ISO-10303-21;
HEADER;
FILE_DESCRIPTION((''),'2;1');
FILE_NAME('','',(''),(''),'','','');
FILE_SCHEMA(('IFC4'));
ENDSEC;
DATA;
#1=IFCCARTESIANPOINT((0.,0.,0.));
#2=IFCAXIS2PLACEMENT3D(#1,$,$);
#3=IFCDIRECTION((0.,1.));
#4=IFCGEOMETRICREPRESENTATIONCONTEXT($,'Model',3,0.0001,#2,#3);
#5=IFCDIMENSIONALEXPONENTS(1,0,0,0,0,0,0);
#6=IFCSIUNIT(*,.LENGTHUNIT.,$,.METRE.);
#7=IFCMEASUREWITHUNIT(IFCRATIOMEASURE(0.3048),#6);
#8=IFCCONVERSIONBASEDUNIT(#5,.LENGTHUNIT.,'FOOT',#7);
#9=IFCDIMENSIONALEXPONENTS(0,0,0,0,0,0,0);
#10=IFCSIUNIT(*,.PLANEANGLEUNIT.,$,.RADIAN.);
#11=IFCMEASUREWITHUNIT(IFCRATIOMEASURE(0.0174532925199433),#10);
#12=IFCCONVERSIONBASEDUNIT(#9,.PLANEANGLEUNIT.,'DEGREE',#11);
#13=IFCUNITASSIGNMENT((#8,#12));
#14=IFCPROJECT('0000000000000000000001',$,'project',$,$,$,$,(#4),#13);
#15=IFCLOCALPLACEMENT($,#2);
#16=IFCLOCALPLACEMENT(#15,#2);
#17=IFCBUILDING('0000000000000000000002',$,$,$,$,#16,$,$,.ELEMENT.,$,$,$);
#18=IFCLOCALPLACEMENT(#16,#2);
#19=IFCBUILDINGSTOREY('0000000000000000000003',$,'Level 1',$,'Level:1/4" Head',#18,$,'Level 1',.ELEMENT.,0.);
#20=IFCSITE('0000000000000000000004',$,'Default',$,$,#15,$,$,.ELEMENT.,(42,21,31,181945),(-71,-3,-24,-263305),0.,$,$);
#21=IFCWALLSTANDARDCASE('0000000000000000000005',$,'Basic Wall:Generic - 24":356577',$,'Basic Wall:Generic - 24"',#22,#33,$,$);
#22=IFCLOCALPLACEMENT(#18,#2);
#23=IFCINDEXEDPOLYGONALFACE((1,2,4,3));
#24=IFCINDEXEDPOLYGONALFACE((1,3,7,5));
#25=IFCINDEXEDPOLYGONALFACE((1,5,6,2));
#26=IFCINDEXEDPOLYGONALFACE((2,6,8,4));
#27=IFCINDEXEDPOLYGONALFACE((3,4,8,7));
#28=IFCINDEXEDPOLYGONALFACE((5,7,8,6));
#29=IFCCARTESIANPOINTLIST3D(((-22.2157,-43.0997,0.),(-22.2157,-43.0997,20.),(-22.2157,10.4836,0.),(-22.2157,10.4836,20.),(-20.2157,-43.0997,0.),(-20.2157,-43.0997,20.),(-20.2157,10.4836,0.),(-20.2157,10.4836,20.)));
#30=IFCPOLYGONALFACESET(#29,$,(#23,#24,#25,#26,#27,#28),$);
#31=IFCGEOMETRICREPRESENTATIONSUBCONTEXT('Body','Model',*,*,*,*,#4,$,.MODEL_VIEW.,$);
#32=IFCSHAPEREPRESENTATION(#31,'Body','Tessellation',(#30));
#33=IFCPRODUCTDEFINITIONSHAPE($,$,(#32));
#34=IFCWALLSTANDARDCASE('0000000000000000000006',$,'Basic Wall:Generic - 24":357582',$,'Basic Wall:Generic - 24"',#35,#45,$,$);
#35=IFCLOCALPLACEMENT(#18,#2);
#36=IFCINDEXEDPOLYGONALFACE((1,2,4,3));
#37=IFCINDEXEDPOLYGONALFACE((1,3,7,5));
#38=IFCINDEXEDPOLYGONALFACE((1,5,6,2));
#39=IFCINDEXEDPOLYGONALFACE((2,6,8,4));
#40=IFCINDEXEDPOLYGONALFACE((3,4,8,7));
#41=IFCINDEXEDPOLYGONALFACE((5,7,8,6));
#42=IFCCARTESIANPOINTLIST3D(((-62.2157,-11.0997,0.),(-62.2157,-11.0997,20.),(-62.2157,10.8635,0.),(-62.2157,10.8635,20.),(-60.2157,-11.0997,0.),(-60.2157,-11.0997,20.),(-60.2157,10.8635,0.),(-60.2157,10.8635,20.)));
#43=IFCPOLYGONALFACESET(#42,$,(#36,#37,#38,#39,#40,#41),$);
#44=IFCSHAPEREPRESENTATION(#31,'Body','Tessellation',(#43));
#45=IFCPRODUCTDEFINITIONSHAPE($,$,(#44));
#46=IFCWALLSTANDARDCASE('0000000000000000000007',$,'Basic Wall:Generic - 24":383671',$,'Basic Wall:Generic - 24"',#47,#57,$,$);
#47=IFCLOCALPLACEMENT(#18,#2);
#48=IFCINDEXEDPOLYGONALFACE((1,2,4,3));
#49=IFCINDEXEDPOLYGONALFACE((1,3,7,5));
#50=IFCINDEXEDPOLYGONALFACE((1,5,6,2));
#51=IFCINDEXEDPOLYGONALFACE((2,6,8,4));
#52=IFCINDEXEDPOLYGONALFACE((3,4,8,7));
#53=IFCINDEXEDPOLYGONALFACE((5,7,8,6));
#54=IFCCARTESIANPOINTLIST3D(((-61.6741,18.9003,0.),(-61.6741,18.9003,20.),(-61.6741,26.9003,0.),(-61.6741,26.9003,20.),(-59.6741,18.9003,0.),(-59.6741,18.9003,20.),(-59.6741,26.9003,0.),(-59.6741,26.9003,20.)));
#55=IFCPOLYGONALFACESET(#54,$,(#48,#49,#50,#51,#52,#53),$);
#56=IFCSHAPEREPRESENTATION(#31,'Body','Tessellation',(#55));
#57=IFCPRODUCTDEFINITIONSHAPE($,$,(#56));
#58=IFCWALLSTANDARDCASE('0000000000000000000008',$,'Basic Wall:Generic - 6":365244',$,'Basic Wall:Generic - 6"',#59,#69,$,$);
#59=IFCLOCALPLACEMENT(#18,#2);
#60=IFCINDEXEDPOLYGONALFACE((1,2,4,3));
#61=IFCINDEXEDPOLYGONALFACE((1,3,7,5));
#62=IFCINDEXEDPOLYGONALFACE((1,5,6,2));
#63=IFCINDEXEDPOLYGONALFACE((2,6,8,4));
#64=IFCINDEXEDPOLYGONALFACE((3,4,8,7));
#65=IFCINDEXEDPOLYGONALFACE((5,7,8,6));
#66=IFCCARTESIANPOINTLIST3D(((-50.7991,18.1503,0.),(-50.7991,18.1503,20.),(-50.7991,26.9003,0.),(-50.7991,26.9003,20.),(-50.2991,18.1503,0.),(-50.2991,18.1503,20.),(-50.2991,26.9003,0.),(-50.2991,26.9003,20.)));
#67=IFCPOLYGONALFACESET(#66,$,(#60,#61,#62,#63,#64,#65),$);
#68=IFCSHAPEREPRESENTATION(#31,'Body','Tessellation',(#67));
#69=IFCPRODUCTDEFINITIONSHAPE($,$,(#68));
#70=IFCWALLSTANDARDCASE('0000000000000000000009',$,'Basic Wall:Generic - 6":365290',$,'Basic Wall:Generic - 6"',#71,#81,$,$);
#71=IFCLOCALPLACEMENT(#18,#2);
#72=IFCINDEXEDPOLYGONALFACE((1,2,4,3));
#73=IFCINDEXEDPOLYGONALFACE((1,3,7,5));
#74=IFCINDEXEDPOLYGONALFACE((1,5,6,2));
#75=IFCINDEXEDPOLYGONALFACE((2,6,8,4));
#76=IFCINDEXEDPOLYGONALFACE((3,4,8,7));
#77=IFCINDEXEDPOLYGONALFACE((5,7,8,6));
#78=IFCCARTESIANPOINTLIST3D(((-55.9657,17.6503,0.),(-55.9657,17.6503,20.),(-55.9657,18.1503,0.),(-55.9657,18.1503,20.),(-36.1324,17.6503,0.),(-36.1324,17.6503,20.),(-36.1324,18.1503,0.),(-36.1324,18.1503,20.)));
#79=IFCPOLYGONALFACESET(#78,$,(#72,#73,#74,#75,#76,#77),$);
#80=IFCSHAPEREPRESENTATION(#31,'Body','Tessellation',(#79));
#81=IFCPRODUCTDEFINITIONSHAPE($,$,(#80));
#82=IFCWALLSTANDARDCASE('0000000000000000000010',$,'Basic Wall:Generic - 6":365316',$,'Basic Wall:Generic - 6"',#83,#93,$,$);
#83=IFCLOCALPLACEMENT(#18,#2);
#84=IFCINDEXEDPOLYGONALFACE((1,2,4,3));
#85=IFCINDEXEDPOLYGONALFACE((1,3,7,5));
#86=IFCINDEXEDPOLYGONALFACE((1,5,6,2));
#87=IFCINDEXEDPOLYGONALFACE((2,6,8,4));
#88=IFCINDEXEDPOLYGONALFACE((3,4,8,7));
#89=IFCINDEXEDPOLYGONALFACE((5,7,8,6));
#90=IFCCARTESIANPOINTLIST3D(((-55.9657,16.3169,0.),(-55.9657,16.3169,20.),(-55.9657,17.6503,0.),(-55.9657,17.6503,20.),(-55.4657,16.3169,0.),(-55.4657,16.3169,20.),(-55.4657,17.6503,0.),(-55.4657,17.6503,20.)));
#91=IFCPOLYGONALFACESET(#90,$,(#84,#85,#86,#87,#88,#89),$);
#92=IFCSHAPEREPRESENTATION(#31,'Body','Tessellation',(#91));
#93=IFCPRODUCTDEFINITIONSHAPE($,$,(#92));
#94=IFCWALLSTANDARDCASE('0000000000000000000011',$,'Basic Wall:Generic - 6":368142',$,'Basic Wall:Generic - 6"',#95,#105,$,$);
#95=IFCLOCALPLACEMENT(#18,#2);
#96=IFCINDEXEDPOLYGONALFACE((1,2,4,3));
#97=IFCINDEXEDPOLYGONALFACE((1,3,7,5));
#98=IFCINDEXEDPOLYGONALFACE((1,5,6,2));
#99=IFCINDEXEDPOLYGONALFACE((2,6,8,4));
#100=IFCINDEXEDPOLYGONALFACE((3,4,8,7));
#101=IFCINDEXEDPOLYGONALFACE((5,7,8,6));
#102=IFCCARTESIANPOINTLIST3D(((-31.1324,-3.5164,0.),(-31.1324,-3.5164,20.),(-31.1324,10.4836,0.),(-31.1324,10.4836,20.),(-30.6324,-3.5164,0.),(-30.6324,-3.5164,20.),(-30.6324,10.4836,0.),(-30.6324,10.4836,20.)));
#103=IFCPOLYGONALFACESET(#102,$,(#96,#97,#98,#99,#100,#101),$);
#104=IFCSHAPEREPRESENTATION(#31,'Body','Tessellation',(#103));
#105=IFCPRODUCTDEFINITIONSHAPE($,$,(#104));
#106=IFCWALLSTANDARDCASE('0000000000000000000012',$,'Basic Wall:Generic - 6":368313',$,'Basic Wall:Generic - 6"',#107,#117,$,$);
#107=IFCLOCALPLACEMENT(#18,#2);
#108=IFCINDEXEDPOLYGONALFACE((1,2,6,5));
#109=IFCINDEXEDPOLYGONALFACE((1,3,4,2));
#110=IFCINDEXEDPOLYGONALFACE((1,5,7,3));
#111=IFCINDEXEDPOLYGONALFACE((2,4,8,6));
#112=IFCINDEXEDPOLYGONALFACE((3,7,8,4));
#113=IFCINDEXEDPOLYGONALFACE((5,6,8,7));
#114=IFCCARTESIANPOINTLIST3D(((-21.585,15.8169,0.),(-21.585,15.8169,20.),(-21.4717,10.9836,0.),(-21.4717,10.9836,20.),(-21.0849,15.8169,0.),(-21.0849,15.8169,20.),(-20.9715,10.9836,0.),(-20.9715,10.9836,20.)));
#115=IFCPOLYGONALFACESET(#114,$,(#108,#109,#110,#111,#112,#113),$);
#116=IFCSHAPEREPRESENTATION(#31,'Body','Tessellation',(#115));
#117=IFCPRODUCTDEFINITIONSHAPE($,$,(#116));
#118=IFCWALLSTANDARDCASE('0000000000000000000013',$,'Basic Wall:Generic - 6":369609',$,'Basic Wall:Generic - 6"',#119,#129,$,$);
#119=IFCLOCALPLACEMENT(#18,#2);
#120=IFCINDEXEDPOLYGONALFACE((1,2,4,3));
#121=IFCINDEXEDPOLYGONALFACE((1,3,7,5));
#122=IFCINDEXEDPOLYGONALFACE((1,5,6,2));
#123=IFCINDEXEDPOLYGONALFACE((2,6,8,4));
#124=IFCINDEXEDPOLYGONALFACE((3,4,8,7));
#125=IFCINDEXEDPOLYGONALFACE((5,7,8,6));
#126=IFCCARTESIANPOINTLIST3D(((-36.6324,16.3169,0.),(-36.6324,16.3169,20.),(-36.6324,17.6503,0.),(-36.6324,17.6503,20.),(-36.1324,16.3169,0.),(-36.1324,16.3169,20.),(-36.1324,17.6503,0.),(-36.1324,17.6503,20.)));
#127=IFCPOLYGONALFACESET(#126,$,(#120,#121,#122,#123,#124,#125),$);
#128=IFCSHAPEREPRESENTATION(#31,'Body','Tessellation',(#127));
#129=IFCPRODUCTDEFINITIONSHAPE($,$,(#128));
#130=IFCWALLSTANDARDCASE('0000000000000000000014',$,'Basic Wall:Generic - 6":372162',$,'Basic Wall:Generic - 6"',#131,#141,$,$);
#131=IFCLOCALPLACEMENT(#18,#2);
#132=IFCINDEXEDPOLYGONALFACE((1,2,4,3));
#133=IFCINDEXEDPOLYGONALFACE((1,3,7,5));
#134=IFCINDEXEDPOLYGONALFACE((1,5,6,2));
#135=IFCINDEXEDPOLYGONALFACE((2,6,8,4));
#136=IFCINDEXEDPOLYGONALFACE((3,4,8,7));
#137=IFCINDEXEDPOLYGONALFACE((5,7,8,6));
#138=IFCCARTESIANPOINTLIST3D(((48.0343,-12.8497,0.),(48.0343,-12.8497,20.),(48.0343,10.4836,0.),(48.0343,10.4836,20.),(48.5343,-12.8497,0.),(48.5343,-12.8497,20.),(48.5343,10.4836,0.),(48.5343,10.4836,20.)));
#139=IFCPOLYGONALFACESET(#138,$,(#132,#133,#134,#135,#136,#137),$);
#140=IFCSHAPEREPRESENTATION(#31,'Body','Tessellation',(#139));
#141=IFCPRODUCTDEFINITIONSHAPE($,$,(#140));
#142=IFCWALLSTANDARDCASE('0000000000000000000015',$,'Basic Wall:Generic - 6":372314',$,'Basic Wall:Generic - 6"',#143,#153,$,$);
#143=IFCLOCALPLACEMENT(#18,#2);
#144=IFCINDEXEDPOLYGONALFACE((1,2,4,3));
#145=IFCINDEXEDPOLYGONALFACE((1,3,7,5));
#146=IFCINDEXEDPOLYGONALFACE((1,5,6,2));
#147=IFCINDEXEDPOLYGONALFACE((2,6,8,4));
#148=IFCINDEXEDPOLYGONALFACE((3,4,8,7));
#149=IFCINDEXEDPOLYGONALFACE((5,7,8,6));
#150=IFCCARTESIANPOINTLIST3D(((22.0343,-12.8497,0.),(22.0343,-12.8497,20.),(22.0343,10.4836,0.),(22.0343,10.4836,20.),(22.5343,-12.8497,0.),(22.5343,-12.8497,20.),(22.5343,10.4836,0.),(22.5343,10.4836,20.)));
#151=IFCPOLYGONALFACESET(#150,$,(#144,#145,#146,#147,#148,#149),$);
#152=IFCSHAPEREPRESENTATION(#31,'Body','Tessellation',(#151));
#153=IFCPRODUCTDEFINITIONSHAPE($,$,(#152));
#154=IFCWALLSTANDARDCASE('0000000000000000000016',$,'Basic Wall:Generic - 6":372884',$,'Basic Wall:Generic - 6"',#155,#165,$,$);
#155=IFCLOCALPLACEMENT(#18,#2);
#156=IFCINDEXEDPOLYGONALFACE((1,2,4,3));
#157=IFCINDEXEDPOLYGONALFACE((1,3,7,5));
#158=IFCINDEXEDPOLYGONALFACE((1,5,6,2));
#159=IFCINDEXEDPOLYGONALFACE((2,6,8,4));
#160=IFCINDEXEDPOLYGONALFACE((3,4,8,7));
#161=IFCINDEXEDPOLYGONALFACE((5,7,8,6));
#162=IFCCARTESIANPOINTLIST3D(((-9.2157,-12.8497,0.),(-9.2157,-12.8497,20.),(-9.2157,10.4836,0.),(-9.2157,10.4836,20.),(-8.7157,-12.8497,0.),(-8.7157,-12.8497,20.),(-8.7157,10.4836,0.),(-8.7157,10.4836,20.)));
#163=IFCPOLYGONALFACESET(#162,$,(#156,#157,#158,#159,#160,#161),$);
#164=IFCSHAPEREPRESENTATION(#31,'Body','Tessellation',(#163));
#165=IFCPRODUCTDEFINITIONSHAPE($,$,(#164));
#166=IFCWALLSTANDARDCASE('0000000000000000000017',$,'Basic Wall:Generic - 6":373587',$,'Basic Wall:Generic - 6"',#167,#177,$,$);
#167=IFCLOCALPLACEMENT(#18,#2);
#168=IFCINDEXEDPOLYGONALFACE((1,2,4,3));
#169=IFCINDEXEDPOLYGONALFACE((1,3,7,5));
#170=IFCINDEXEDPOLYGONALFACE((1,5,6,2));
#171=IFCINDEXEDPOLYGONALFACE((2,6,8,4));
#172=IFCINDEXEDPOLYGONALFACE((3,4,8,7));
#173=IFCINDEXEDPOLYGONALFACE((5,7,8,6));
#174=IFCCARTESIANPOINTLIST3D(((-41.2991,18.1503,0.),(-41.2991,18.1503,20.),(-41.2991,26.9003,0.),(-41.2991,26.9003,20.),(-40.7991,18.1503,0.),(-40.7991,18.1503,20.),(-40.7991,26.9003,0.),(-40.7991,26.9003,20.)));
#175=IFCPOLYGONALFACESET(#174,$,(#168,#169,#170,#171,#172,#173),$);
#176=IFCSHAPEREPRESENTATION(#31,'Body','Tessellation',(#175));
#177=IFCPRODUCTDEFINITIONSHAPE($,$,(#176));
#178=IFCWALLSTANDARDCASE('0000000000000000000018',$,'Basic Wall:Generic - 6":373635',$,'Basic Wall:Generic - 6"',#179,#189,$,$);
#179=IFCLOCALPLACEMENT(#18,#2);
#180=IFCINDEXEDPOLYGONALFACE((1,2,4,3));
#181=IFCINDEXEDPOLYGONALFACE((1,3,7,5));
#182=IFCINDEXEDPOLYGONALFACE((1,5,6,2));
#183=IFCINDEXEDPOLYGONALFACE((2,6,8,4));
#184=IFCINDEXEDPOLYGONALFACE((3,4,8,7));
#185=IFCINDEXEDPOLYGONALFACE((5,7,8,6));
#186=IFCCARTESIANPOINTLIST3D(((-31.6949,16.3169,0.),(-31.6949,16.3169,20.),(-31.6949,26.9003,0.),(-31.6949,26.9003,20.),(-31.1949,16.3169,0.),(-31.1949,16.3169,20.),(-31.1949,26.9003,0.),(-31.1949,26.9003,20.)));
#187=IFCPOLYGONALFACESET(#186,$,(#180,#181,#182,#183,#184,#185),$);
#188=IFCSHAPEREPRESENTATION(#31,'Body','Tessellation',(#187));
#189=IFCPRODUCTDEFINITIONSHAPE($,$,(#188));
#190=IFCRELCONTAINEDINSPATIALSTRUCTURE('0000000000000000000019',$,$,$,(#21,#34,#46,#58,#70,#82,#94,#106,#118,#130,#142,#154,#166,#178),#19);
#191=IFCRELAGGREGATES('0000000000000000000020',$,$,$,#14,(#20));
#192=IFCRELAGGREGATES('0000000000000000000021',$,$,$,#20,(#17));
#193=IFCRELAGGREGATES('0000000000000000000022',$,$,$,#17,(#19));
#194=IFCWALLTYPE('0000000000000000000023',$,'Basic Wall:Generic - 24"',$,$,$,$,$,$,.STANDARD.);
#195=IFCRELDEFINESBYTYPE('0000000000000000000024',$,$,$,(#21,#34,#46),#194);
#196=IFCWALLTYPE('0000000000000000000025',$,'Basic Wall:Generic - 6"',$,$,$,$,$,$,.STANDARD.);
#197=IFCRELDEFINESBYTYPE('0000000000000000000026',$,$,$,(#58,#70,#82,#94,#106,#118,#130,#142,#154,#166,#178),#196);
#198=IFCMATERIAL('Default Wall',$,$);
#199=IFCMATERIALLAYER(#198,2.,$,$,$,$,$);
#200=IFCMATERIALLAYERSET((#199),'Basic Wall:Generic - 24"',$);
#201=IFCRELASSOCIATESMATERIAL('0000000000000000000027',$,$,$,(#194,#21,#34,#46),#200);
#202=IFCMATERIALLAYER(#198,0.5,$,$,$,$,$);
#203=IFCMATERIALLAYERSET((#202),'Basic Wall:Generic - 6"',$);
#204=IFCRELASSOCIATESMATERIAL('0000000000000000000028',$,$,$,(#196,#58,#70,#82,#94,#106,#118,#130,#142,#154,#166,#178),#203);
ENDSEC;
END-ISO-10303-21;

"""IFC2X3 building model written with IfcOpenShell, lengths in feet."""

from ifc_helpers import new_model, entity, si_unit, converted_unit, direction, frame, frame_2d, origin, place, context, subcontext, project, spatial, polyline, rectangle, outline, extrude, material, layer, layer_set, layer_usage, type_object, element, save


model = new_model("IFC2X3")

# Units and contexts
model_context = context("Model", 3, precision=0.0001, world=origin(), true_north=direction((0.0, 1.0)))
body_context = subcontext(model_context, "Body", "Model", "MODEL_VIEW")
ifc_project = project(units=[converted_unit("LENGTHUNIT", "FOOT", entity("IfcRatioMeasure", 0.3048), si_unit("LENGTHUNIT", "METRE"), dimensions=[1, 0, 0, 0, 0, 0, 0]), converted_unit("PLANEANGLEUNIT", "DEGREE", entity("IfcRatioMeasure", 0.0174532925199433), si_unit("PLANEANGLEUNIT", "RADIAN"), dimensions=[0, 0, 0, 0, 0, 0, 0])], contexts=[model_context])

# Site, building, storey
site_placement = place(None, origin())
site = spatial("IfcSite", under=ifc_project, at=site_placement, Name="Default", CompositionType="ELEMENT", RefLatitude=(42, 21, 31, 181945), RefLongitude=(-71, -3, -24, -263305), RefElevation=0.0)
building_placement = place(site_placement, origin())
building = spatial("IfcBuilding", under=site, at=building_placement, CompositionType="ELEMENT")
storey_placement = place(building_placement, origin())
storey = spatial("IfcBuildingStorey", under=building, at=storey_placement, Name="Level 1", ObjectType="Level:1/4\" Head", LongName="Level 1", CompositionType="ELEMENT", Elevation=0.0)

# Walls
ifc_material = material(Name="Default Wall")
ifc_layer_1 = layer(ifc_material, 2.0)
ifc_layer_set_1 = layer_set([ifc_layer_1], Name="Basic Wall:Generic - 24\"")
ifc_layer_usage_1 = layer_usage(ifc_layer_set_1, "AXIS2", "NEGATIVE", 1.0)
wall_type_1 = type_object("IfcWallType", Name="Basic Wall:Generic - 24\"", PredefinedType="STANDARD", material=ifc_layer_set_1)
wall_1_placement = place(storey_placement, frame((-21.2157, 10.4836, 0.0), z_axis=(0.0, 0.0, 1.0), x_axis=(0.0, -1.0, 0.0)))
element("IfcWallStandardCase", 1, at=wall_1_placement, inside=storey, type_object=wall_type_1, material=ifc_layer_usage_1, Name="Basic Wall:Generic - 24\":356577", ObjectType="Basic Wall:Generic - 24\"", context=body_context, shape_type="SweptSolid", body=[
    extrude(rectangle(XDim=53.5833, YDim=2.0, at=frame_2d((26.7917, 0.0), x_axis=(-1.0, 0.0))), origin(), (0.0, 0.0, 1.0), 20.0),
])
ifc_layer_usage_2 = layer_usage(ifc_layer_set_1, "AXIS2", "NEGATIVE", 1.0)
wall_2_placement = place(storey_placement, frame((-61.2157, 10.8635, 0.0), z_axis=(0.0, 0.0, 1.0), x_axis=(0.0, -1.0, 0.0)))
element("IfcWallStandardCase", 2, at=wall_2_placement, inside=storey, type_object=wall_type_1, material=ifc_layer_usage_2, Name="Basic Wall:Generic - 24\":357582", ObjectType="Basic Wall:Generic - 24\"", context=body_context, shape_type="SweptSolid", body=[
    extrude(rectangle(XDim=21.9633, YDim=2.0, at=frame_2d((10.9816, 0.0), x_axis=(-1.0, 0.0))), origin(), (0.0, 0.0, 1.0), 20.0),
])
ifc_layer_usage_3 = layer_usage(ifc_layer_set_1, "AXIS2", "NEGATIVE", 1.0)
wall_3_placement = place(storey_placement, frame((-60.6741, 18.9003, 0.0), z_axis=(0.0, 0.0, 1.0), x_axis=(0.0, 1.0, 0.0)))
element("IfcWallStandardCase", 3, at=wall_3_placement, inside=storey, type_object=wall_type_1, material=ifc_layer_usage_3, Name="Basic Wall:Generic - 24\":383671", ObjectType="Basic Wall:Generic - 24\"", context=body_context, shape_type="SweptSolid", body=[
    extrude(rectangle(XDim=8.0, YDim=2.0, at=frame_2d((4.0, 0.0), x_axis=(-1.0, 0.0))), origin(), (0.0, 0.0, 1.0), 20.0),
])
ifc_layer_2 = layer(ifc_material, 0.5)
ifc_layer_set_2 = layer_set([ifc_layer_2], Name="Basic Wall:Generic - 6\"")
ifc_layer_usage_4 = layer_usage(ifc_layer_set_2, "AXIS2", "NEGATIVE", 0.25)
wall_type_2 = type_object("IfcWallType", Name="Basic Wall:Generic - 6\"", PredefinedType="STANDARD", material=ifc_layer_set_2)
wall_4_placement = place(storey_placement, frame((-50.5491, 26.9003, 0.0), z_axis=(0.0, 0.0, 1.0), x_axis=(0.0, -1.0, 0.0)))
element("IfcWallStandardCase", 4, at=wall_4_placement, inside=storey, type_object=wall_type_2, material=ifc_layer_usage_4, Name="Basic Wall:Generic - 6\":365244", ObjectType="Basic Wall:Generic - 6\"", context=body_context, shape_type="SweptSolid", body=[
    extrude(rectangle(XDim=8.75, YDim=0.5, at=frame_2d((4.375, 0.0), x_axis=(-1.0, 0.0))), origin(), (0.0, 0.0, 1.0), 20.0),
])
ifc_layer_usage_5 = layer_usage(ifc_layer_set_2, "AXIS2", "NEGATIVE", 0.25)
wall_5_placement = place(storey_placement, frame((-36.1324, 17.9003, 0.0), z_axis=(0.0, 0.0, 1.0), x_axis=(-1.0, 0.0, 0.0)))
element("IfcWallStandardCase", 5, at=wall_5_placement, inside=storey, type_object=wall_type_2, material=ifc_layer_usage_5, Name="Basic Wall:Generic - 6\":365290", ObjectType="Basic Wall:Generic - 6\"", context=body_context, shape_type="SweptSolid", body=[
    extrude(rectangle(XDim=19.8333, YDim=0.5, at=frame_2d((9.9167, 0.0), x_axis=(-1.0, 0.0))), origin(), (0.0, 0.0, 1.0), 20.0),
])
ifc_layer_usage_6 = layer_usage(ifc_layer_set_2, "AXIS2", "NEGATIVE", 0.25)
wall_6_placement = place(storey_placement, frame((-55.7157, 17.6503, 0.0), z_axis=(0.0, 0.0, 1.0), x_axis=(0.0, -1.0, 0.0)))
element("IfcWallStandardCase", 6, at=wall_6_placement, inside=storey, type_object=wall_type_2, material=ifc_layer_usage_6, Name="Basic Wall:Generic - 6\":365316", ObjectType="Basic Wall:Generic - 6\"", context=body_context, shape_type="SweptSolid", body=[
    extrude(rectangle(XDim=1.3333, YDim=0.5, at=frame_2d((0.6667, 0.0), x_axis=(-1.0, 0.0))), origin(), (0.0, 0.0, 1.0), 20.0),
])
ifc_layer_usage_7 = layer_usage(ifc_layer_set_2, "AXIS2", "NEGATIVE", 0.25)
wall_7_placement = place(storey_placement, frame((-30.8824, 10.4836, 0.0), z_axis=(0.0, 0.0, 1.0), x_axis=(0.0, -1.0, 0.0)))
element("IfcWallStandardCase", 7, at=wall_7_placement, inside=storey, type_object=wall_type_2, material=ifc_layer_usage_7, Name="Basic Wall:Generic - 6\":368142", ObjectType="Basic Wall:Generic - 6\"", context=body_context, shape_type="SweptSolid", body=[
    extrude(rectangle(XDim=14.0, YDim=0.5, at=frame_2d((7.0, 0.0), x_axis=(-1.0, 0.0))), origin(), (0.0, 0.0, 1.0), 20.0),
])
ifc_layer_usage_8 = layer_usage(ifc_layer_set_2, "AXIS2", "NEGATIVE", 0.25)
wall_8_placement = place(storey_placement, frame((-21.2215, 10.9777, 0.0), z_axis=(0.0, 0.0, 1.0), x_axis=(-0.023446, 0.999725, 0.0)))
element("IfcWallStandardCase", 8, at=wall_8_placement, inside=storey, type_object=wall_type_2, material=ifc_layer_usage_8, Name="Basic Wall:Generic - 6\":368313", ObjectType="Basic Wall:Generic - 6\"", context=body_context, shape_type="SweptSolid", body=[
    extrude(outline(polyline([(4.8347, -0.25), (4.8464, 0.25), (0.0117, 0.25), (0.0, -0.25), (4.8347, -0.25)])), origin(), (0.0, 0.0, 1.0), 20.0),
])
ifc_layer_usage_9 = layer_usage(ifc_layer_set_2, "AXIS2", "NEGATIVE", 0.25)
wall_9_placement = place(storey_placement, frame((-36.3824, 17.6503, 0.0), z_axis=(0.0, 0.0, 1.0), x_axis=(0.0, -1.0, 0.0)))
element("IfcWallStandardCase", 9, at=wall_9_placement, inside=storey, type_object=wall_type_2, material=ifc_layer_usage_9, Name="Basic Wall:Generic - 6\":369609", ObjectType="Basic Wall:Generic - 6\"", context=body_context, shape_type="SweptSolid", body=[
    extrude(rectangle(XDim=1.3333, YDim=0.5, at=frame_2d((0.6667, 0.0), x_axis=(-1.0, 0.0))), origin(), (0.0, 0.0, 1.0), 20.0),
])
ifc_layer_usage_10 = layer_usage(ifc_layer_set_2, "AXIS2", "NEGATIVE", 0.25)
wall_10_placement = place(storey_placement, frame((48.2843, 10.4836, 0.0), z_axis=(0.0, 0.0, 1.0), x_axis=(0.0, -1.0, 0.0)))
element("IfcWallStandardCase", 10, at=wall_10_placement, inside=storey, type_object=wall_type_2, material=ifc_layer_usage_10, Name="Basic Wall:Generic - 6\":372162", ObjectType="Basic Wall:Generic - 6\"", context=body_context, shape_type="SweptSolid", body=[
    extrude(rectangle(XDim=23.3333, YDim=0.5, at=frame_2d((11.6667, 0.0), x_axis=(-1.0, 0.0))), origin(), (0.0, 0.0, 1.0), 20.0),
])
ifc_layer_usage_11 = layer_usage(ifc_layer_set_2, "AXIS2", "NEGATIVE", 0.25)
wall_11_placement = place(storey_placement, frame((22.2843, 10.4836, 0.0), z_axis=(0.0, 0.0, 1.0), x_axis=(0.0, -1.0, 0.0)))
element("IfcWallStandardCase", 11, at=wall_11_placement, inside=storey, type_object=wall_type_2, material=ifc_layer_usage_11, Name="Basic Wall:Generic - 6\":372314", ObjectType="Basic Wall:Generic - 6\"", context=body_context, shape_type="SweptSolid", body=[
    extrude(rectangle(XDim=23.3333, YDim=0.5, at=frame_2d((11.6667, 0.0), x_axis=(-1.0, 0.0))), origin(), (0.0, 0.0, 1.0), 20.0),
])
ifc_layer_usage_12 = layer_usage(ifc_layer_set_2, "AXIS2", "NEGATIVE", 0.25)
wall_12_placement = place(storey_placement, frame((-8.9657, 10.4836, 0.0), z_axis=(0.0, 0.0, 1.0), x_axis=(0.0, -1.0, 0.0)))
element("IfcWallStandardCase", 12, at=wall_12_placement, inside=storey, type_object=wall_type_2, material=ifc_layer_usage_12, Name="Basic Wall:Generic - 6\":372884", ObjectType="Basic Wall:Generic - 6\"", context=body_context, shape_type="SweptSolid", body=[
    extrude(rectangle(XDim=23.3333, YDim=0.5, at=frame_2d((11.6667, 0.0), x_axis=(-1.0, 0.0))), origin(), (0.0, 0.0, 1.0), 20.0),
])
ifc_layer_usage_13 = layer_usage(ifc_layer_set_2, "AXIS2", "NEGATIVE", 0.25)
wall_13_placement = place(storey_placement, frame((-41.0491, 26.9003, 0.0), z_axis=(0.0, 0.0, 1.0), x_axis=(0.0, -1.0, 0.0)))
element("IfcWallStandardCase", 13, at=wall_13_placement, inside=storey, type_object=wall_type_2, material=ifc_layer_usage_13, Name="Basic Wall:Generic - 6\":373587", ObjectType="Basic Wall:Generic - 6\"", context=body_context, shape_type="SweptSolid", body=[
    extrude(rectangle(XDim=8.75, YDim=0.5, at=frame_2d((4.375, 0.0), x_axis=(-1.0, 0.0))), origin(), (0.0, 0.0, 1.0), 20.0),
])
ifc_layer_usage_14 = layer_usage(ifc_layer_set_2, "AXIS2", "NEGATIVE", 0.25)
wall_14_placement = place(storey_placement, frame((-31.4449, 16.3169, 0.0), z_axis=(0.0, 0.0, 1.0), x_axis=(0.0, 1.0, 0.0)))
element("IfcWallStandardCase", 14, at=wall_14_placement, inside=storey, type_object=wall_type_2, material=ifc_layer_usage_14, Name="Basic Wall:Generic - 6\":373635", ObjectType="Basic Wall:Generic - 6\"", context=body_context, shape_type="SweptSolid", body=[
    extrude(rectangle(XDim=10.5833, YDim=0.5, at=frame_2d((5.2917, 0.0), x_axis=(-1.0, 0.0))), origin(), (0.0, 0.0, 1.0), 20.0),
])

save(model, "model.ifc")
